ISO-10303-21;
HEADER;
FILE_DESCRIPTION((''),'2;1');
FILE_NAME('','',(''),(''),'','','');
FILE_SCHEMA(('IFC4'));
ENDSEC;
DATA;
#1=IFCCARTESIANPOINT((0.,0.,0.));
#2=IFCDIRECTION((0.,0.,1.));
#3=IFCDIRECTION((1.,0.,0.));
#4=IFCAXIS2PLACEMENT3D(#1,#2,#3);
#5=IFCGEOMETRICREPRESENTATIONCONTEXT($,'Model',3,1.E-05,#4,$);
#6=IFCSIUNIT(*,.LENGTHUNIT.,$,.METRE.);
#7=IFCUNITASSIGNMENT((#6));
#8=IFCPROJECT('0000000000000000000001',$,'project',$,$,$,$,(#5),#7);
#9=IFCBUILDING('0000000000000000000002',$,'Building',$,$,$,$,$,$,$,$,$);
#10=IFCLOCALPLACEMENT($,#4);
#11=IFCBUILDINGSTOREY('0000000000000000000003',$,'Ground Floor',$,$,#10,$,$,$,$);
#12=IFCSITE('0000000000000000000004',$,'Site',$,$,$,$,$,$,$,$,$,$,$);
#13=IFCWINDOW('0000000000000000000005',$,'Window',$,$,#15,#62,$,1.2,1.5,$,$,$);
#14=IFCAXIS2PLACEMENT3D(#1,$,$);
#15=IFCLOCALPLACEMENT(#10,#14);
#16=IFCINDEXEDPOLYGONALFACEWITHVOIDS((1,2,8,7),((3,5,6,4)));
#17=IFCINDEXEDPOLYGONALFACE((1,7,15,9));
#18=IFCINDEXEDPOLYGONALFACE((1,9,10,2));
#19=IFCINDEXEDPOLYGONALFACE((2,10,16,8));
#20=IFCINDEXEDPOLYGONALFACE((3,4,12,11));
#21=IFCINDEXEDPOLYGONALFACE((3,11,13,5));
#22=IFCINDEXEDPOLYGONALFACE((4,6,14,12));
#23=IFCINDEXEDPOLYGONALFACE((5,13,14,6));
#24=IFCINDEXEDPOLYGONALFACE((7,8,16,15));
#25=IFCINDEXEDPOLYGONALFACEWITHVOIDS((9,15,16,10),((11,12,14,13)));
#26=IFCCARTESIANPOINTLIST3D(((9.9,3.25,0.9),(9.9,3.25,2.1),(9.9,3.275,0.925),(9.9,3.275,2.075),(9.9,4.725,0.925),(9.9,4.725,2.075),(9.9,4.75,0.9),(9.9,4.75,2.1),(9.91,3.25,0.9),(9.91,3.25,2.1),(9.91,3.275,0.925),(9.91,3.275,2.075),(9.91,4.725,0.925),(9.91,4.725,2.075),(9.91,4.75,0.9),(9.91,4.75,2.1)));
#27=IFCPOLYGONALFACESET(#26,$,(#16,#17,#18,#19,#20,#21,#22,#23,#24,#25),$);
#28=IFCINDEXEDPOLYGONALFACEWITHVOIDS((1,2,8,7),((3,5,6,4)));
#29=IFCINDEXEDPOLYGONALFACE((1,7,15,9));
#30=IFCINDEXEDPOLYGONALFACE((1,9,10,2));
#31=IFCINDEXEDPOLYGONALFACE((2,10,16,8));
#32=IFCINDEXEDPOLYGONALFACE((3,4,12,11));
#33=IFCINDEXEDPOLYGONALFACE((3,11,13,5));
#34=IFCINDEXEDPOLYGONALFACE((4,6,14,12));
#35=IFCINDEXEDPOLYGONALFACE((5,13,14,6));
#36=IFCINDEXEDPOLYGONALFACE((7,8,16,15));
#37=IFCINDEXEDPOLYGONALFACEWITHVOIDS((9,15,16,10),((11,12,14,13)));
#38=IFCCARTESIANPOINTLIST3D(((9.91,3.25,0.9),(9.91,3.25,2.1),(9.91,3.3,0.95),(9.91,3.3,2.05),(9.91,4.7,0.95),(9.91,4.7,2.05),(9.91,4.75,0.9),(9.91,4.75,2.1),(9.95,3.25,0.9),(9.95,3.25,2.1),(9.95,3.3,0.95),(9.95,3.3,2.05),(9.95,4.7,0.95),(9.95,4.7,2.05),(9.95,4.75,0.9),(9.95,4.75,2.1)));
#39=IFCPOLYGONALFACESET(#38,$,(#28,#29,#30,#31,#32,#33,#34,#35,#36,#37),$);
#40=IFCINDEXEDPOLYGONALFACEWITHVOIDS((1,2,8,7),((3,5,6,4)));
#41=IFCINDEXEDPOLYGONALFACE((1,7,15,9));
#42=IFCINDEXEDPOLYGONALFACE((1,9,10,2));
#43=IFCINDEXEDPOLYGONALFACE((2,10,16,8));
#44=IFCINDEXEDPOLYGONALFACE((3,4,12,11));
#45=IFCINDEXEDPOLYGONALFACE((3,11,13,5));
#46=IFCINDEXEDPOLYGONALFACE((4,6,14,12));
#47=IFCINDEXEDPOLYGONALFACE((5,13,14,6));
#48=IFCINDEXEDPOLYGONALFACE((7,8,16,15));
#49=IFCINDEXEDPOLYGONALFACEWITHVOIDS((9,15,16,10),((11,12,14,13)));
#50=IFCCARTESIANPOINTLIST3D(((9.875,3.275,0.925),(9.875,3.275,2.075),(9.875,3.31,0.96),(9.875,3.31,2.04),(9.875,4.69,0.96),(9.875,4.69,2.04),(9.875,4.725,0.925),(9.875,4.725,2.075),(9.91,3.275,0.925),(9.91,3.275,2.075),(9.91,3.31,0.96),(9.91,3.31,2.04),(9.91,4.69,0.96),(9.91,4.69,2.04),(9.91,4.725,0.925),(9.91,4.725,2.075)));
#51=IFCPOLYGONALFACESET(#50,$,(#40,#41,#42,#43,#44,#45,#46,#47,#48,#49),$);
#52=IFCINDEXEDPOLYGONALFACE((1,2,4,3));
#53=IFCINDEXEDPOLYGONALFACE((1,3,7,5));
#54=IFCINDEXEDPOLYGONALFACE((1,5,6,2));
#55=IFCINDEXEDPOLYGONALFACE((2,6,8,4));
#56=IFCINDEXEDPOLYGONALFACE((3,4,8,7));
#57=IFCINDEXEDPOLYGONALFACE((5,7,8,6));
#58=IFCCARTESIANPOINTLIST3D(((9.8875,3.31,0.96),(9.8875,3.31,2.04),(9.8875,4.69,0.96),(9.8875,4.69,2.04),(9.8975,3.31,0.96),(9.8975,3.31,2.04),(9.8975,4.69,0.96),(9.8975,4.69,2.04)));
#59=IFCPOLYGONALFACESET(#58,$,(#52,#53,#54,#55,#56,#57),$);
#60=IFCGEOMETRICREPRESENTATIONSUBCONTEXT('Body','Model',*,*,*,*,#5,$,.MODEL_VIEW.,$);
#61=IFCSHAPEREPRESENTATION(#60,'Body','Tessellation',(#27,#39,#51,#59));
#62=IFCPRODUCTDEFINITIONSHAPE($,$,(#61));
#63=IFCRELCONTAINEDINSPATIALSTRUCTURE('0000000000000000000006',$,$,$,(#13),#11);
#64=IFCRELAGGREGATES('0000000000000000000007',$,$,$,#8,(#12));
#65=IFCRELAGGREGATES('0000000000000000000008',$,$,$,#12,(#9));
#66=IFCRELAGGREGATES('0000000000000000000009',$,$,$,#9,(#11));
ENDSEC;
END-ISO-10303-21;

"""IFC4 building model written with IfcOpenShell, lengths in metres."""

from ifc_helpers import new_model, si_unit, frame, origin_with_axes, place, context, subcontext, project, spatial, line, indexed_curve, outline, extrude, element, save


model = new_model("IFC4")

# Units and contexts
model_context = context("Model", 3, precision=1e-05, world=origin_with_axes())
body_context = subcontext(model_context, "Body", "Model", "MODEL_VIEW")
ifc_project = project(units=[si_unit("LENGTHUNIT", "METRE")], contexts=[model_context])

# Site, building, storey
site = spatial("IfcSite", under=ifc_project, Name="Site")
building = spatial("IfcBuilding", under=site, Name="Building")
storey_placement = place(None, origin_with_axes())
storey = spatial("IfcBuildingStorey", under=building, at=storey_placement, Name="Ground Floor")

# Window
for number, where, z_axis, x_axis, name in (
    (1, (10.0, 3.25, 0.9), (0.0, 0.0, 1.0), (0.0, 1.0, 0.0), "Window"),
):
    element("IfcWindow", number, at=place(storey_placement, frame(where, z_axis=z_axis, x_axis=x_axis)), inside=storey, Name=name, OverallHeight=1.2, OverallWidth=1.5, context=body_context, shape_type="SweptSolid", body=[
        extrude(outline(indexed_curve([(0.0, 0.0), (1.5, 0.0), (1.5, 1.2), (0.0, 1.2)], segments=[line(1, 2, 3, 4, 1)]), holes=[indexed_curve([(0.025, 0.025), (1.475, 0.025), (1.475, 1.175), (0.025, 1.175)], segments=[line(1, 2, 3, 4, 1)])]), frame((0.0, 0.09, 0.0), z_axis=(0.0, -1.0, 0.0), x_axis=(1.0, 0.0, 0.0)), (0.0, 0.0, -1.0), 0.01),
        extrude(outline(indexed_curve([(0.0, 0.0), (1.5, 0.0), (1.5, 1.2), (0.0, 1.2)], segments=[line(1, 2, 3, 4, 1)]), holes=[indexed_curve([(0.05, 0.05), (1.45, 0.05), (1.45, 1.15), (0.05, 1.15)], segments=[line(1, 2, 3, 4, 1)])]), frame((0.0, 0.05, 0.0), z_axis=(0.0, -1.0, 0.0), x_axis=(1.0, 0.0, 0.0)), (0.0, 0.0, -1.0), 0.04),
        extrude(outline(indexed_curve([(0.0, 0.0), (1.45, 0.0), (1.45, 1.15), (0.0, 1.15)], segments=[line(1, 2, 3, 4, 1)]), holes=[indexed_curve([(0.035, 0.035), (1.415, 0.035), (1.415, 1.115), (0.035, 1.115)], segments=[line(1, 2, 3, 4, 1)])]), frame((0.025, 0.09, 0.025), z_axis=(0.0, -1.0, 0.0), x_axis=(1.0, 0.0, 0.0)), (0.0, 0.0, -1.0), 0.035),
        extrude(outline(indexed_curve([(0.035, 0.035), (1.415, 0.035), (1.415, 1.115), (0.035, 1.115)], segments=[line(1, 2, 3, 4, 1)])), frame((0.025, 0.1025, 0.025), z_axis=(0.0, -1.0, 0.0), x_axis=(1.0, 0.0, 0.0)), (0.0, 0.0, -1.0), 0.01),
    ])

save(model, "model.ifc")
